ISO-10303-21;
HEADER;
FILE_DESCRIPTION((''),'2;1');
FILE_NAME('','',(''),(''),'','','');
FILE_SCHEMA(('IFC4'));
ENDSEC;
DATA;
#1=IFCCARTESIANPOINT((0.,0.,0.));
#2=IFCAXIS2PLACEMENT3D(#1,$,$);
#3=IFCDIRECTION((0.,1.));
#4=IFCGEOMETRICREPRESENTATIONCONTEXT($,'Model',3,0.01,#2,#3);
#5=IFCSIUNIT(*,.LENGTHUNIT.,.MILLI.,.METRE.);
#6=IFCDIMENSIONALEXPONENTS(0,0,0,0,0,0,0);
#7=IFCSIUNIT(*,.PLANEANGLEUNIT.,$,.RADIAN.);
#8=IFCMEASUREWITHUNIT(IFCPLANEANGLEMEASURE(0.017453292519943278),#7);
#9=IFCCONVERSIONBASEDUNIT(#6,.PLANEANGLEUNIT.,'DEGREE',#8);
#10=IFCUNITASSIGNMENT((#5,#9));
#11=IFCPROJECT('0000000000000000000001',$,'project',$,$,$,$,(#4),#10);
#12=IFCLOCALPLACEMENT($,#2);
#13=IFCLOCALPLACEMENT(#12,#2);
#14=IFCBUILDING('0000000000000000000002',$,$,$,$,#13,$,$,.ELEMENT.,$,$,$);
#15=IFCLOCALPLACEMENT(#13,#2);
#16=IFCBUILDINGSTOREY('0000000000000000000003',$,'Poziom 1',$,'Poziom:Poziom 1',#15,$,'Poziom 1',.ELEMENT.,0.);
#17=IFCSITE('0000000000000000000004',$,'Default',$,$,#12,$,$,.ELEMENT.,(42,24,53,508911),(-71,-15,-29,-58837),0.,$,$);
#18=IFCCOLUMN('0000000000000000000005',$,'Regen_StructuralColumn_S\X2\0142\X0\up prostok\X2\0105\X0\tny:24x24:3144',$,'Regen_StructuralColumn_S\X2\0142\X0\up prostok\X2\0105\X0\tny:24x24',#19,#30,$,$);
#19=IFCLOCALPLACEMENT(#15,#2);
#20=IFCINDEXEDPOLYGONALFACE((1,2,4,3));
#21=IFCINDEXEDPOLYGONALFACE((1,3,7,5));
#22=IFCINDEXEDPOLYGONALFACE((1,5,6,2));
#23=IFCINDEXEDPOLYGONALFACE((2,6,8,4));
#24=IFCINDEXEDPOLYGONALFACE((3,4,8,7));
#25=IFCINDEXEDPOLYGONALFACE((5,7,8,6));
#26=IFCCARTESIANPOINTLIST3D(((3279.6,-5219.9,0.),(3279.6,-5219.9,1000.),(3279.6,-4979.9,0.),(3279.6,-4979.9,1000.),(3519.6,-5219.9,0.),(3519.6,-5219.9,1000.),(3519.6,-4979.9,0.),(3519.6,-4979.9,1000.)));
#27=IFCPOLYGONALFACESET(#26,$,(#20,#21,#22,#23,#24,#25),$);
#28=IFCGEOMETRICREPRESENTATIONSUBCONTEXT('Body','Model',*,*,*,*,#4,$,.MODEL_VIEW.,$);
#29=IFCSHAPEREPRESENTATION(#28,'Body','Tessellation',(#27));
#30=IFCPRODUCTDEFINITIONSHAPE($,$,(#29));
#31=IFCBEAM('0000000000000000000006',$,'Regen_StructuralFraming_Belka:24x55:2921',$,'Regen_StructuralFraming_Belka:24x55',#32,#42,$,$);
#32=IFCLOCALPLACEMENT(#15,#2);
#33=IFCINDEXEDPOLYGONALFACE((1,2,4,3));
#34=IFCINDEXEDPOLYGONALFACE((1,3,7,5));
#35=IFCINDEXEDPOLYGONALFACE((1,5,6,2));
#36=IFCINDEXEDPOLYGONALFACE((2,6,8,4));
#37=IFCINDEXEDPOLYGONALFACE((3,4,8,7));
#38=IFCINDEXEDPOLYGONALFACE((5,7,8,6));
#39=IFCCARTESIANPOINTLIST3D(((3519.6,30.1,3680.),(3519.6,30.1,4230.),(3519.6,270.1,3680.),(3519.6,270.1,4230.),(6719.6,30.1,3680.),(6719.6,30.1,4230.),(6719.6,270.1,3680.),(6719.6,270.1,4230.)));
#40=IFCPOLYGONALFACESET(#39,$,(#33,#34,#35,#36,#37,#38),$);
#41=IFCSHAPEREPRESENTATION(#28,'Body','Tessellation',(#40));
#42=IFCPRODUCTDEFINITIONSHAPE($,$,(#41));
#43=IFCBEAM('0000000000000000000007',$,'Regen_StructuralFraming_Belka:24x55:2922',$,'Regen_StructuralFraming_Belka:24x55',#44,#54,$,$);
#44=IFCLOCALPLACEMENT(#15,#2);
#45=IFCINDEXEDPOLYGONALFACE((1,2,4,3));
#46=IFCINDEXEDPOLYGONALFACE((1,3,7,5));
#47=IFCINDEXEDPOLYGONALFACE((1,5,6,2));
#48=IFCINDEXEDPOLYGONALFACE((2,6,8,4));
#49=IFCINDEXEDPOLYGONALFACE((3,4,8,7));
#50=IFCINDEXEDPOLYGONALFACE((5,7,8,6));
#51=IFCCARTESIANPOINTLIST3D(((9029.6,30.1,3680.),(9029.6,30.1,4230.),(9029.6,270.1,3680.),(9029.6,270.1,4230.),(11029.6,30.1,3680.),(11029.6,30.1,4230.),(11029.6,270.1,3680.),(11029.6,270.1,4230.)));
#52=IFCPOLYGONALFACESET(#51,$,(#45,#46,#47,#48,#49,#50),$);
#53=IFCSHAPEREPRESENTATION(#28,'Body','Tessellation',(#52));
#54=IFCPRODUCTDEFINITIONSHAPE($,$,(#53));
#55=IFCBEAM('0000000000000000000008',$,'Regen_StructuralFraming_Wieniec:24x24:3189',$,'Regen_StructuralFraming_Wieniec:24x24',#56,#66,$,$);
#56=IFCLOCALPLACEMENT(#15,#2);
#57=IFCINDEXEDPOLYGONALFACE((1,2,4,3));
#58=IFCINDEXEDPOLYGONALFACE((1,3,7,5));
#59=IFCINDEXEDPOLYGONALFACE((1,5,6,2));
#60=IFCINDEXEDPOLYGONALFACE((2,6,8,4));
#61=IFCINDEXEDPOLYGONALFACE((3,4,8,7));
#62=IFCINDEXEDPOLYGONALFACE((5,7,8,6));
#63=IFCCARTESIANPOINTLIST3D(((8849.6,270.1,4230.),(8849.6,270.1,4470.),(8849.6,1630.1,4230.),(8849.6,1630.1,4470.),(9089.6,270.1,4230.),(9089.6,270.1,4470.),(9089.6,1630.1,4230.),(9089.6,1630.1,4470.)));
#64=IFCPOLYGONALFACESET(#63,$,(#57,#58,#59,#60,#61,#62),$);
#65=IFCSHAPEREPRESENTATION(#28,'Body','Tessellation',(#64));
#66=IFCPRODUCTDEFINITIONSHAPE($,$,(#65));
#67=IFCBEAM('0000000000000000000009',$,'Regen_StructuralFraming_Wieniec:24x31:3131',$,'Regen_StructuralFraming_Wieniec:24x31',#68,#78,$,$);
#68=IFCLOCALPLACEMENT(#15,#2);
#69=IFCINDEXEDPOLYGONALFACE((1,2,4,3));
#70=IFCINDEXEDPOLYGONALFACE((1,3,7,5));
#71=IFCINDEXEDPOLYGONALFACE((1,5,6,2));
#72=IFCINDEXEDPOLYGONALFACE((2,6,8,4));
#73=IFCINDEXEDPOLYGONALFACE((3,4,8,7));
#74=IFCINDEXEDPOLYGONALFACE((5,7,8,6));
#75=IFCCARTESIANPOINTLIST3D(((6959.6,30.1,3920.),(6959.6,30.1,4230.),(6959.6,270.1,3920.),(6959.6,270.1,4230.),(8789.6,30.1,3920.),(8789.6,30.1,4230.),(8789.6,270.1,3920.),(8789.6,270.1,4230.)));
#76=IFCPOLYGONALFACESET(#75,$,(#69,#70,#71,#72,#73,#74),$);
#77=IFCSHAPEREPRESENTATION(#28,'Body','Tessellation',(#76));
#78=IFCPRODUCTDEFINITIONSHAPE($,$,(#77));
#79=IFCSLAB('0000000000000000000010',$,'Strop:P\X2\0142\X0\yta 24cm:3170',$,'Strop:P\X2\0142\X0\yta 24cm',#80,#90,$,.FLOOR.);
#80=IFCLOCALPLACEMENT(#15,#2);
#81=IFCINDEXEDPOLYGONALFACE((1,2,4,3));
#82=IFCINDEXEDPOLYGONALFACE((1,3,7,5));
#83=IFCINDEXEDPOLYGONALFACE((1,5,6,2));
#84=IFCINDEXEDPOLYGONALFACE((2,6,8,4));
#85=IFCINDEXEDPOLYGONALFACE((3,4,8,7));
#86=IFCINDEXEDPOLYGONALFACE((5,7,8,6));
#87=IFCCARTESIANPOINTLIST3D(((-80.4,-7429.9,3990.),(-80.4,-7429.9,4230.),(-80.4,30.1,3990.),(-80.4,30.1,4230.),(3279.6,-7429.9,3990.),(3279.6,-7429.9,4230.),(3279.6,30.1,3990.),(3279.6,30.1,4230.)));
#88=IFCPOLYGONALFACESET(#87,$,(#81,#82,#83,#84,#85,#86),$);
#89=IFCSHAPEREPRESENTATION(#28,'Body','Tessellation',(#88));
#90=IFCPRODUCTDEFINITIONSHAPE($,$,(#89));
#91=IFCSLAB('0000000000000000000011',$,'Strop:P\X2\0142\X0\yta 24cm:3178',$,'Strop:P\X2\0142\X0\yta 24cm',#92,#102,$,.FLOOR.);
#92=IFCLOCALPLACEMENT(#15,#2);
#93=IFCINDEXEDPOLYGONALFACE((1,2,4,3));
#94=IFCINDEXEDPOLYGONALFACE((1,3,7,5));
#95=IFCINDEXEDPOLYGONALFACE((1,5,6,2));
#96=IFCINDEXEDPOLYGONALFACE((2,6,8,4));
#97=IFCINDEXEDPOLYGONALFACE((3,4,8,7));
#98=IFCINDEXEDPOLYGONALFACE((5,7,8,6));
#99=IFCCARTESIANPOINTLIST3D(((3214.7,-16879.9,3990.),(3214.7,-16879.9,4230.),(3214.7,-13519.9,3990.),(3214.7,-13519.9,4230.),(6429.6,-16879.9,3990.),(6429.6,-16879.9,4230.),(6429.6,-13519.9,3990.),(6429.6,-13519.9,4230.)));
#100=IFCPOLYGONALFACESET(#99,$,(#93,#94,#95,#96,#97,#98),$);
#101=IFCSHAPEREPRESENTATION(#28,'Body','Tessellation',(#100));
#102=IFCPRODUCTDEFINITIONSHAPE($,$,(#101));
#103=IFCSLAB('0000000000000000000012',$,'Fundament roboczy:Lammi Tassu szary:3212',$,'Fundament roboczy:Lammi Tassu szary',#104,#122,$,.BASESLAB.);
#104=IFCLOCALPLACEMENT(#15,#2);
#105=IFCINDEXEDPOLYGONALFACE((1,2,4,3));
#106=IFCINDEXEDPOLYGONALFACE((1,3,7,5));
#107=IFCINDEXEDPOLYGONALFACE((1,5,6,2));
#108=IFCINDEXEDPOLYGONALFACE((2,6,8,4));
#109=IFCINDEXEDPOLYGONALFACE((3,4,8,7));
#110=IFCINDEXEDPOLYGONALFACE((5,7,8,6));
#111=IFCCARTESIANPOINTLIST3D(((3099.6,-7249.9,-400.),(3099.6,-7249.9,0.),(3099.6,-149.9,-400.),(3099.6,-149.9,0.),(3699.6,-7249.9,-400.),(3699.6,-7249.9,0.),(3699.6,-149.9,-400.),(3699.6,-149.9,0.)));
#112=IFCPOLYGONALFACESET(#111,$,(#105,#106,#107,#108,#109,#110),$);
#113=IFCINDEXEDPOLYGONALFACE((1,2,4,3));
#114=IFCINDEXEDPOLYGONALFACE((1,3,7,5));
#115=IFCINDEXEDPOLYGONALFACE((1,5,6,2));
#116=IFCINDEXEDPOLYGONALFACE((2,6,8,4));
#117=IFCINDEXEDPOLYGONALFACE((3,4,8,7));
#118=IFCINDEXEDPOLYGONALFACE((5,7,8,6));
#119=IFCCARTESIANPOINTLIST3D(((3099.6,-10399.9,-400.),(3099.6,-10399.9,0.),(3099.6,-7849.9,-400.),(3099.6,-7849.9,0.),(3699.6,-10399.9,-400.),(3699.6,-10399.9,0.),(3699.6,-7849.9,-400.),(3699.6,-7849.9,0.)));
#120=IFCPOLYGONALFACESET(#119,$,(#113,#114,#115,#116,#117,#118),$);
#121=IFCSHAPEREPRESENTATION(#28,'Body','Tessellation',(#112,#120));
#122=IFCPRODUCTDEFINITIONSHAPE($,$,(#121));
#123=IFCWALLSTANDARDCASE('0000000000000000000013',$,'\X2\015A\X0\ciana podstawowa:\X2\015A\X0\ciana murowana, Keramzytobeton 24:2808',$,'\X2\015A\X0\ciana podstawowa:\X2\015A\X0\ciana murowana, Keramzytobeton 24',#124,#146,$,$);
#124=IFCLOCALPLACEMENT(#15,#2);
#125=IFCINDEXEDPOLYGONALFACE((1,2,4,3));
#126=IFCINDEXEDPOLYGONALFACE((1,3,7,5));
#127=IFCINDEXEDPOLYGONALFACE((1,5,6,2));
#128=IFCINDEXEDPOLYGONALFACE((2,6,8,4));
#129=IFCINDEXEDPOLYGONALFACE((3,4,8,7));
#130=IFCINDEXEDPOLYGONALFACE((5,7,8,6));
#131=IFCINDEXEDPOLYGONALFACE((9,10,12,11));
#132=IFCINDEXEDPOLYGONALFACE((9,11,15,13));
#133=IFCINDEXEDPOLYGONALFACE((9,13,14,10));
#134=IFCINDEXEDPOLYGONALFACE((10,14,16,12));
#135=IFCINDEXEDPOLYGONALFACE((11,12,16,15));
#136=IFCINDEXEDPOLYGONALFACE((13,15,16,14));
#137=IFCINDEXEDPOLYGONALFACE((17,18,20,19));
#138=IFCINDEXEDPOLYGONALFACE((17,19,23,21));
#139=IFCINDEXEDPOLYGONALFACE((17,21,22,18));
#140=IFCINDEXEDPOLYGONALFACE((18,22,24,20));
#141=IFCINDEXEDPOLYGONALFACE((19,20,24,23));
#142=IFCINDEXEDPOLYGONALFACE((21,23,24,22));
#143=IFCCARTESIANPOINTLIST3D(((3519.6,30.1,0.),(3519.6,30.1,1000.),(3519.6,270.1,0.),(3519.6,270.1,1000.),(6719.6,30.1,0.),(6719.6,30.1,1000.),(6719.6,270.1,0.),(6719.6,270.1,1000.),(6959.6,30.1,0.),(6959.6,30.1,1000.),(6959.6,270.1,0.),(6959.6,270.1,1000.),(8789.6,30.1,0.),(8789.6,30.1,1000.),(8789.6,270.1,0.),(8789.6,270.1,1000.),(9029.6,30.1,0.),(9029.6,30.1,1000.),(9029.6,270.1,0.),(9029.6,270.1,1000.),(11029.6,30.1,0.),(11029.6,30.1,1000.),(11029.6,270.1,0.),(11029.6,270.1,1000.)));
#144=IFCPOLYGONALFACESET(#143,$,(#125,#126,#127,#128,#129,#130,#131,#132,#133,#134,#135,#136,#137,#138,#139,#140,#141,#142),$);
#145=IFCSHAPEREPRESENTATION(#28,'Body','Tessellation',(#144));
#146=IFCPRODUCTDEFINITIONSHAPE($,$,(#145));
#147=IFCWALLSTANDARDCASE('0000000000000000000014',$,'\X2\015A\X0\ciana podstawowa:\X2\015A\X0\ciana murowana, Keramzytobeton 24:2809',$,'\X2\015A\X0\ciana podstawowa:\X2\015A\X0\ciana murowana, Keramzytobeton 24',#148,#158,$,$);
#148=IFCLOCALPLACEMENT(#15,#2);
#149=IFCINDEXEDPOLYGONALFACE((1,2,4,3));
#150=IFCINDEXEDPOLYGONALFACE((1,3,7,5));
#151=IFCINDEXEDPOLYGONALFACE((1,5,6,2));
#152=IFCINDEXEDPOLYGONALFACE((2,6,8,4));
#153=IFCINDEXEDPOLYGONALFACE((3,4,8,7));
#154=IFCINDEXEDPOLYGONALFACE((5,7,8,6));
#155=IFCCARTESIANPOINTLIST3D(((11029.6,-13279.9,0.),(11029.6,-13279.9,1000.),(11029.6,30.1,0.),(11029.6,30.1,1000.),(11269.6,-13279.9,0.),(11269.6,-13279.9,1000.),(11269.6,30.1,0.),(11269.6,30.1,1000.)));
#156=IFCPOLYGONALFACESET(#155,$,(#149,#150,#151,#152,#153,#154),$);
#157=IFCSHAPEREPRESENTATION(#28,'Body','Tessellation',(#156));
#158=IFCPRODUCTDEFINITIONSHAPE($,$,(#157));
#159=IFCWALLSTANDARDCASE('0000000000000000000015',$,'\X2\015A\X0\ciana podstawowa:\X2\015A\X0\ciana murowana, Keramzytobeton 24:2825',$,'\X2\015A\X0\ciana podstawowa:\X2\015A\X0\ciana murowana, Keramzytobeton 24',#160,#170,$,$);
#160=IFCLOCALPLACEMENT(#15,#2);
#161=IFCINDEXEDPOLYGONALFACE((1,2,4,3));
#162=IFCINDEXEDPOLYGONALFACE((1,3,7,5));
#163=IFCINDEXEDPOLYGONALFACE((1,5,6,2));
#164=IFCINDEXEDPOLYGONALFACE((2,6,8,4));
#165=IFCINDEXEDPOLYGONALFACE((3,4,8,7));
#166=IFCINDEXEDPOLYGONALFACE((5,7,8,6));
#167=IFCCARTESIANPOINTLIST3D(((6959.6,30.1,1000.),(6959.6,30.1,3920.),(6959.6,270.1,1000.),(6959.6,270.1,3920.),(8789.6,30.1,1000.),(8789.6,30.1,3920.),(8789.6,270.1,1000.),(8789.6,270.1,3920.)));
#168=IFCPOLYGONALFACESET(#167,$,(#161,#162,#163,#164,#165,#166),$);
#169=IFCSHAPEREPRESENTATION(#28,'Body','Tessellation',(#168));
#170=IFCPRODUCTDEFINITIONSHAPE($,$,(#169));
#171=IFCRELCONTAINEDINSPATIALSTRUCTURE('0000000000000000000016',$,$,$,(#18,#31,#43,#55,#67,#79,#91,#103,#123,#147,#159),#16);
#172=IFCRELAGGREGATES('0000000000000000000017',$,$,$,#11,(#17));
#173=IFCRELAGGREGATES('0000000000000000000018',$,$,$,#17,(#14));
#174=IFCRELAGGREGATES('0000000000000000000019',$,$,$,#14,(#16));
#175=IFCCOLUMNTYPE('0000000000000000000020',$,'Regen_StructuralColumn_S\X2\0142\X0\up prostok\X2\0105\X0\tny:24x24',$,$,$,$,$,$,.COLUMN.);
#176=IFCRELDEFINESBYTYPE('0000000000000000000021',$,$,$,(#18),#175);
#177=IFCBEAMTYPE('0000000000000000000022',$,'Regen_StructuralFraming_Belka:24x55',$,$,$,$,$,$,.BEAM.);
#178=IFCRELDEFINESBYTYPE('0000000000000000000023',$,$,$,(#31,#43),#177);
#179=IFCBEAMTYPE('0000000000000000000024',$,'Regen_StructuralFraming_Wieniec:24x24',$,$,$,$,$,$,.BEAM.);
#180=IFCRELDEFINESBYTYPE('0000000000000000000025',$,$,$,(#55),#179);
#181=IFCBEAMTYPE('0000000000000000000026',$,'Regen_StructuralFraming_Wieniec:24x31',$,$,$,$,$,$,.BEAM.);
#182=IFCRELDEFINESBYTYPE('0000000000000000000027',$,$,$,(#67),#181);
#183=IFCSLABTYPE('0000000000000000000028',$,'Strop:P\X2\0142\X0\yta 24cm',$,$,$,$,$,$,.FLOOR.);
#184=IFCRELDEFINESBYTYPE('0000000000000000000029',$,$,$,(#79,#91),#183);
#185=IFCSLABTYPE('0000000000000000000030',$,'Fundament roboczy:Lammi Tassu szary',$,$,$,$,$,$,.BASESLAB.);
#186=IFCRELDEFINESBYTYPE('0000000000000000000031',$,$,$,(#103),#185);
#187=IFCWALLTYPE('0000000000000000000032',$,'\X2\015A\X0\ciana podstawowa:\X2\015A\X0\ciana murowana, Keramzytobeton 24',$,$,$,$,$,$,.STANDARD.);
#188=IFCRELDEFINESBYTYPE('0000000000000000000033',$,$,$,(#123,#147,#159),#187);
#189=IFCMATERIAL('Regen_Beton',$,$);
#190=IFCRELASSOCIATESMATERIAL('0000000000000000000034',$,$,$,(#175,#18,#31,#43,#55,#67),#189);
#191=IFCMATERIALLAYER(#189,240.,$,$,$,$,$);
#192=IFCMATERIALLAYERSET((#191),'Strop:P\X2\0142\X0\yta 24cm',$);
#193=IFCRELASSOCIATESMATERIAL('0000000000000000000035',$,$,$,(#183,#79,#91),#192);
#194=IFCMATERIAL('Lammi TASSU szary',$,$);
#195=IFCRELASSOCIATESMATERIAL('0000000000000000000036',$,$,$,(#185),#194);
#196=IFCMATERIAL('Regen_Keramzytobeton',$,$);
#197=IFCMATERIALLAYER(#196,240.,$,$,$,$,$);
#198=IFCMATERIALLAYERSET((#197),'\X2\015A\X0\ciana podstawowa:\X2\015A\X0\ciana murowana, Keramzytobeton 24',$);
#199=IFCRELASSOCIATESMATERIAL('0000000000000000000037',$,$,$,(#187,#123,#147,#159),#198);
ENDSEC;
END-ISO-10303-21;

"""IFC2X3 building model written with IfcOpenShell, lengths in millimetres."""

from ifc_helpers import new_model, entity, si_unit, converted_unit, direction, frame, frame_2d, origin, origin_2d_with_axis, place, context, subcontext, project, spatial, rectangle, extrude, source, transform, mapped, material, layer, layer_set, layer_usage, type_object, type_shapes, element, save


model = new_model("IFC2X3")

# Units and contexts
model_context = context("Model", 3, precision=0.01, world=origin(), true_north=direction((0.0, 1.0)))
body_context = subcontext(model_context, "Body", "Model", "MODEL_VIEW")
ifc_project = project(units=[si_unit("LENGTHUNIT", "METRE", prefix="MILLI"), converted_unit("PLANEANGLEUNIT", "DEGREE", entity("IfcPlaneAngleMeasure", 0.017453292519943278), si_unit("PLANEANGLEUNIT", "RADIAN"), dimensions=[0, 0, 0, 0, 0, 0, 0])], contexts=[model_context])

# Site, building, storey
site_placement = place(None, origin())
site = spatial("IfcSite", under=ifc_project, at=site_placement, Name="Default", CompositionType="ELEMENT", RefLatitude=(42, 24, 53, 508911), RefLongitude=(-71, -15, -29, -58837), RefElevation=0.0)
building_placement = place(site_placement, origin())
building = spatial("IfcBuilding", under=site, at=building_placement, CompositionType="ELEMENT")
storey_placement = place(building_placement, origin())
storey = spatial("IfcBuildingStorey", under=building, at=storey_placement, Name="Poziom 1", ObjectType="Poziom:Poziom 1", LongName="Poziom 1", CompositionType="ELEMENT", Elevation=0.0)

# Column
ifc_material_1 = material(Name="Regen_Beton")
column_type = type_object("IfcColumnType", Name="Regen_StructuralColumn_Słup prostokątny:24x24", PredefinedType="COLUMN", material=ifc_material_1)
shared_shape = source(origin(), body_context, "Body", "SweptSolid", [
    extrude(rectangle(XDim=240.0, YDim=240.0, at=frame_2d((0.0, 0.0), x_axis=(1.0, 0.0))), frame((3399.6, -5099.9, 0.0), z_axis=(0.0, 0.0, 1.0), x_axis=(-1.0, 0.0, 0.0)), (0.0, 0.0, 1.0), 1000.0),
])
type_shapes(column_type, [shared_shape])
column_placement = place(storey_placement, origin())
element("IfcColumn", 1, at=column_placement, inside=storey, type_object=column_type, material=ifc_material_1, Name="Regen_StructuralColumn_Słup prostokątny:24x24:3144", ObjectType="Regen_StructuralColumn_Słup prostokątny:24x24", context=body_context, shape_type="MappedRepresentation", body=[
    mapped(shared_shape, transform((0.0, 0.0, 0.0), scale=1.0)),
])

# Beams
beam_type_1 = type_object("IfcBeamType", Name="Regen_StructuralFraming_Belka:24x55", PredefinedType="BEAM")
beam_1_placement = place(storey_placement, frame((3519.6, 150.1, 4230.0)))
element("IfcBeam", 2, at=beam_1_placement, inside=storey, type_object=beam_type_1, material=ifc_material_1, Name="Regen_StructuralFraming_Belka:24x55:2921", ObjectType="Regen_StructuralFraming_Belka:24x55", context=body_context, shape_type="SweptSolid", body=[
    extrude(rectangle(XDim=550.0, YDim=240.0, at=frame_2d((0.0, 0.0), x_axis=(1.0, 0.0))), frame((0.0, 0.0, -275.0), z_axis=(1.0, 0.0, 0.0), x_axis=(0.0, 0.0, -1.0)), (0.0, 0.0, 1.0), 3200.0),
])
beam_2_placement = place(storey_placement, frame((9029.6, 150.1, 4230.0)))
element("IfcBeam", 3, at=beam_2_placement, inside=storey, type_object=beam_type_1, material=ifc_material_1, Name="Regen_StructuralFraming_Belka:24x55:2922", ObjectType="Regen_StructuralFraming_Belka:24x55", context=body_context, shape_type="SweptSolid", body=[
    extrude(rectangle(XDim=550.0, YDim=240.0, at=frame_2d((0.0, 0.0), x_axis=(1.0, 0.0))), frame((0.0, 0.0, -275.0), z_axis=(1.0, 0.0, 0.0), x_axis=(0.0, 0.0, -1.0)), (0.0, 0.0, 1.0), 2000.0),
])
beam_type_2 = type_object("IfcBeamType", Name="Regen_StructuralFraming_Wieniec:24x24", PredefinedType="BEAM")
beam_3_placement = place(storey_placement, frame((8969.6, 1750.1, 4230.0), z_axis=(0.0, 0.0, 1.0), x_axis=(0.0, -1.0, 0.0)))
element("IfcBeam", 4, at=beam_3_placement, inside=storey, type_object=beam_type_2, material=ifc_material_1, Name="Regen_StructuralFraming_Wieniec:24x24:3189", ObjectType="Regen_StructuralFraming_Wieniec:24x24", context=body_context, shape_type="SweptSolid", body=[
    extrude(rectangle(XDim=240.0, YDim=240.0, at=origin_2d_with_axis()), frame((120.0, 0.0, 120.0), z_axis=(1.0, 0.0, 0.0), x_axis=(0.0, 0.0, -1.0)), (0.0, 0.0, 1.0), 1360.0),
])
beam_type_3 = type_object("IfcBeamType", Name="Regen_StructuralFraming_Wieniec:24x31", PredefinedType="BEAM")
beam_4_placement = place(storey_placement, frame((8789.6, 150.1, 4230.0), z_axis=(0.0, 0.0, 1.0), x_axis=(-1.0, 0.0, 0.0)))
element("IfcBeam", 5, at=beam_4_placement, inside=storey, type_object=beam_type_3, material=ifc_material_1, Name="Regen_StructuralFraming_Wieniec:24x31:3131", ObjectType="Regen_StructuralFraming_Wieniec:24x31", context=body_context, shape_type="SweptSolid", body=[
    extrude(rectangle(XDim=310.0, YDim=240.0, at=origin_2d_with_axis()), frame((0.0, 0.0, -155.0), z_axis=(1.0, 0.0, 0.0), x_axis=(0.0, 0.0, -1.0)), (0.0, 0.0, 1.0), 1830.0),
])

# Slabs
ifc_layer_1 = layer(ifc_material_1, 240.0)
ifc_layer_set_1 = layer_set([ifc_layer_1], Name="Strop:Płyta 24cm")
ifc_layer_usage_1 = layer_usage(ifc_layer_set_1, "AXIS3", "POSITIVE", 0.0)
slab_type_1 = type_object("IfcSlabType", Name="Strop:Płyta 24cm", PredefinedType="FLOOR", material=ifc_layer_set_1)
slab_1_placement = place(storey_placement, origin())
element("IfcSlab", 6, at=slab_1_placement, inside=storey, type_object=slab_type_1, material=ifc_layer_usage_1, Name="Strop:Płyta 24cm:3170", ObjectType="Strop:Płyta 24cm", PredefinedType="FLOOR", context=body_context, shape_type="SweptSolid", body=[
    extrude(rectangle(XDim=7460.0, YDim=3360.0, at=origin_2d_with_axis()), frame((1599.6, -3699.9, 4230.0), z_axis=(0.0, 0.0, -1.0), x_axis=(0.0, 1.0, 0.0)), (0.0, 0.0, 1.0), 240.0),
])
ifc_layer_usage_2 = layer_usage(ifc_layer_set_1, "AXIS3", "POSITIVE", 0.0)
slab_2_placement = place(storey_placement, origin())
element("IfcSlab", 7, at=slab_2_placement, inside=storey, type_object=slab_type_1, material=ifc_layer_usage_2, Name="Strop:Płyta 24cm:3178", ObjectType="Strop:Płyta 24cm", PredefinedType="FLOOR", context=body_context, shape_type="SweptSolid", body=[
    extrude(rectangle(XDim=3360.0, YDim=3214.9, at=frame_2d((0.0, 0.0), x_axis=(1.0, 0.0))), frame((4822.2, -15199.9, 4230.0), z_axis=(0.0, 0.0, -1.0), x_axis=(0.0, 1.0, 0.0)), (0.0, 0.0, 1.0), 240.0),
])
ifc_material_2 = material(Name="Lammi TASSU szary")
slab_type_2 = type_object("IfcSlabType", Name="Fundament roboczy:Lammi Tassu szary", PredefinedType="BASESLAB", material=ifc_material_2)
slab_3_placement = place(storey_placement, origin())
element("IfcSlab", 8, at=slab_3_placement, inside=storey, type_object=slab_type_2, Name="Fundament roboczy:Lammi Tassu szary:3212", ObjectType="Fundament roboczy:Lammi Tassu szary", PredefinedType="BASESLAB", context=body_context, shape_type="SweptSolid", body=[
    extrude(rectangle(XDim=7100.0, YDim=600.0, at=frame_2d((0.0, 0.0), x_axis=(1.0, 0.0))), frame((3399.6, -3699.9, -400.0), z_axis=(0.0, 0.0, 1.0), x_axis=(0.0, 1.0, 0.0)), (0.0, 0.0, 1.0), 400.0),
    extrude(rectangle(XDim=600.0, YDim=2550.0, at=origin_2d_with_axis()), frame((3399.6, -9124.9, -400.0), z_axis=(0.0, 0.0, 1.0), x_axis=(-1.0, 0.0, 0.0)), (0.0, 0.0, 1.0), 400.0),
])

# Wall, openings
ifc_material_3 = material(Name="Regen_Keramzytobeton")
ifc_layer_2 = layer(ifc_material_3, 240.0)
ifc_layer_set_2 = layer_set([ifc_layer_2], Name="Ściana podstawowa:Ściana murowana, Keramzytobeton 24")
ifc_layer_usage_3 = layer_usage(ifc_layer_set_2, "AXIS2", "NEGATIVE", 120.0)
wall_type_1 = type_object("IfcWallType", Name="Ściana podstawowa:Ściana murowana, Keramzytobeton 24", PredefinedType="STANDARD", material=ifc_layer_set_2)
wall_1_placement = place(storey_placement, frame((3519.6, 150.1, 0.0)))
wall_1 = element("IfcWallStandardCase", 9, at=wall_1_placement, inside=storey, type_object=wall_type_1, material=ifc_layer_usage_3, Name="Ściana podstawowa:Ściana murowana, Keramzytobeton 24:2808", ObjectType="Ściana podstawowa:Ściana murowana, Keramzytobeton 24", context=body_context, shape_type="SweptSolid", body=[
    extrude(rectangle(XDim=7510.0, YDim=240.0, at=frame_2d((3755.0, 0.0), x_axis=(-1.0, 0.0))), origin(), (0.0, 0.0, 1.0), 1000.0),
])
opening_1_placement = place(storey_placement, frame((3519.6, 150.1, 0.0)))
element("IfcOpeningElement", 10, at=opening_1_placement, cuts=wall_1, ObjectType="Opening", context=body_context, shape_type="SweptSolid", body=[
    extrude(rectangle(XDim=1000.0, YDim=240.0, at=frame_2d((0.0, 0.0), x_axis=(1.0, 0.0))), frame((5270.0, 0.0, 500.0), z_axis=(1.0, 0.0, 0.0), x_axis=(0.0, 0.0, -1.0)), (0.0, 0.0, 1.0), 240.0),
])
opening_2_placement = place(storey_placement, frame((3519.6, 150.1, 0.0)))
element("IfcOpeningElement", 11, at=opening_2_placement, cuts=wall_1, ObjectType="Opening", context=body_context, shape_type="SweptSolid", body=[
    extrude(rectangle(XDim=1000.0, YDim=240.0, at=origin_2d_with_axis()), frame((3200.0, 0.0, 500.0), z_axis=(1.0, 0.0, 0.0), x_axis=(0.0, 0.0, -1.0)), (0.0, 0.0, 1.0), 240.0),
])

# Walls
ifc_layer_usage_4 = layer_usage(ifc_layer_set_2, "AXIS2", "NEGATIVE", 120.0)
wall_2_placement = place(storey_placement, frame((11149.6, 30.1, 0.0), z_axis=(0.0, 0.0, 1.0), x_axis=(0.0, -1.0, 0.0)))
element("IfcWallStandardCase", 12, at=wall_2_placement, inside=storey, type_object=wall_type_1, material=ifc_layer_usage_4, Name="Ściana podstawowa:Ściana murowana, Keramzytobeton 24:2809", ObjectType="Ściana podstawowa:Ściana murowana, Keramzytobeton 24", context=body_context, shape_type="SweptSolid", body=[
    extrude(rectangle(XDim=13310.0, YDim=240.0, at=frame_2d((6655.0, 0.0), x_axis=(-1.0, 0.0))), origin(), (0.0, 0.0, 1.0), 1000.0),
])
ifc_layer_usage_5 = layer_usage(ifc_layer_set_2, "AXIS2", "NEGATIVE", 120.0)
wall_3_placement = place(storey_placement, frame((6959.6, 150.1, 1000.0)))
element("IfcWallStandardCase", 13, at=wall_3_placement, inside=storey, type_object=wall_type_1, material=ifc_layer_usage_5, Name="Ściana podstawowa:Ściana murowana, Keramzytobeton 24:2825", ObjectType="Ściana podstawowa:Ściana murowana, Keramzytobeton 24", context=body_context, shape_type="SweptSolid", body=[
    extrude(rectangle(XDim=1830.0, YDim=240.0, at=frame_2d((0.0, 0.0), x_axis=(1.0, 0.0))), frame((915.0, 0.0, 0.0)), (0.0, 0.0, 1.0), 2920.0),
])

save(model, "model.ifc")
